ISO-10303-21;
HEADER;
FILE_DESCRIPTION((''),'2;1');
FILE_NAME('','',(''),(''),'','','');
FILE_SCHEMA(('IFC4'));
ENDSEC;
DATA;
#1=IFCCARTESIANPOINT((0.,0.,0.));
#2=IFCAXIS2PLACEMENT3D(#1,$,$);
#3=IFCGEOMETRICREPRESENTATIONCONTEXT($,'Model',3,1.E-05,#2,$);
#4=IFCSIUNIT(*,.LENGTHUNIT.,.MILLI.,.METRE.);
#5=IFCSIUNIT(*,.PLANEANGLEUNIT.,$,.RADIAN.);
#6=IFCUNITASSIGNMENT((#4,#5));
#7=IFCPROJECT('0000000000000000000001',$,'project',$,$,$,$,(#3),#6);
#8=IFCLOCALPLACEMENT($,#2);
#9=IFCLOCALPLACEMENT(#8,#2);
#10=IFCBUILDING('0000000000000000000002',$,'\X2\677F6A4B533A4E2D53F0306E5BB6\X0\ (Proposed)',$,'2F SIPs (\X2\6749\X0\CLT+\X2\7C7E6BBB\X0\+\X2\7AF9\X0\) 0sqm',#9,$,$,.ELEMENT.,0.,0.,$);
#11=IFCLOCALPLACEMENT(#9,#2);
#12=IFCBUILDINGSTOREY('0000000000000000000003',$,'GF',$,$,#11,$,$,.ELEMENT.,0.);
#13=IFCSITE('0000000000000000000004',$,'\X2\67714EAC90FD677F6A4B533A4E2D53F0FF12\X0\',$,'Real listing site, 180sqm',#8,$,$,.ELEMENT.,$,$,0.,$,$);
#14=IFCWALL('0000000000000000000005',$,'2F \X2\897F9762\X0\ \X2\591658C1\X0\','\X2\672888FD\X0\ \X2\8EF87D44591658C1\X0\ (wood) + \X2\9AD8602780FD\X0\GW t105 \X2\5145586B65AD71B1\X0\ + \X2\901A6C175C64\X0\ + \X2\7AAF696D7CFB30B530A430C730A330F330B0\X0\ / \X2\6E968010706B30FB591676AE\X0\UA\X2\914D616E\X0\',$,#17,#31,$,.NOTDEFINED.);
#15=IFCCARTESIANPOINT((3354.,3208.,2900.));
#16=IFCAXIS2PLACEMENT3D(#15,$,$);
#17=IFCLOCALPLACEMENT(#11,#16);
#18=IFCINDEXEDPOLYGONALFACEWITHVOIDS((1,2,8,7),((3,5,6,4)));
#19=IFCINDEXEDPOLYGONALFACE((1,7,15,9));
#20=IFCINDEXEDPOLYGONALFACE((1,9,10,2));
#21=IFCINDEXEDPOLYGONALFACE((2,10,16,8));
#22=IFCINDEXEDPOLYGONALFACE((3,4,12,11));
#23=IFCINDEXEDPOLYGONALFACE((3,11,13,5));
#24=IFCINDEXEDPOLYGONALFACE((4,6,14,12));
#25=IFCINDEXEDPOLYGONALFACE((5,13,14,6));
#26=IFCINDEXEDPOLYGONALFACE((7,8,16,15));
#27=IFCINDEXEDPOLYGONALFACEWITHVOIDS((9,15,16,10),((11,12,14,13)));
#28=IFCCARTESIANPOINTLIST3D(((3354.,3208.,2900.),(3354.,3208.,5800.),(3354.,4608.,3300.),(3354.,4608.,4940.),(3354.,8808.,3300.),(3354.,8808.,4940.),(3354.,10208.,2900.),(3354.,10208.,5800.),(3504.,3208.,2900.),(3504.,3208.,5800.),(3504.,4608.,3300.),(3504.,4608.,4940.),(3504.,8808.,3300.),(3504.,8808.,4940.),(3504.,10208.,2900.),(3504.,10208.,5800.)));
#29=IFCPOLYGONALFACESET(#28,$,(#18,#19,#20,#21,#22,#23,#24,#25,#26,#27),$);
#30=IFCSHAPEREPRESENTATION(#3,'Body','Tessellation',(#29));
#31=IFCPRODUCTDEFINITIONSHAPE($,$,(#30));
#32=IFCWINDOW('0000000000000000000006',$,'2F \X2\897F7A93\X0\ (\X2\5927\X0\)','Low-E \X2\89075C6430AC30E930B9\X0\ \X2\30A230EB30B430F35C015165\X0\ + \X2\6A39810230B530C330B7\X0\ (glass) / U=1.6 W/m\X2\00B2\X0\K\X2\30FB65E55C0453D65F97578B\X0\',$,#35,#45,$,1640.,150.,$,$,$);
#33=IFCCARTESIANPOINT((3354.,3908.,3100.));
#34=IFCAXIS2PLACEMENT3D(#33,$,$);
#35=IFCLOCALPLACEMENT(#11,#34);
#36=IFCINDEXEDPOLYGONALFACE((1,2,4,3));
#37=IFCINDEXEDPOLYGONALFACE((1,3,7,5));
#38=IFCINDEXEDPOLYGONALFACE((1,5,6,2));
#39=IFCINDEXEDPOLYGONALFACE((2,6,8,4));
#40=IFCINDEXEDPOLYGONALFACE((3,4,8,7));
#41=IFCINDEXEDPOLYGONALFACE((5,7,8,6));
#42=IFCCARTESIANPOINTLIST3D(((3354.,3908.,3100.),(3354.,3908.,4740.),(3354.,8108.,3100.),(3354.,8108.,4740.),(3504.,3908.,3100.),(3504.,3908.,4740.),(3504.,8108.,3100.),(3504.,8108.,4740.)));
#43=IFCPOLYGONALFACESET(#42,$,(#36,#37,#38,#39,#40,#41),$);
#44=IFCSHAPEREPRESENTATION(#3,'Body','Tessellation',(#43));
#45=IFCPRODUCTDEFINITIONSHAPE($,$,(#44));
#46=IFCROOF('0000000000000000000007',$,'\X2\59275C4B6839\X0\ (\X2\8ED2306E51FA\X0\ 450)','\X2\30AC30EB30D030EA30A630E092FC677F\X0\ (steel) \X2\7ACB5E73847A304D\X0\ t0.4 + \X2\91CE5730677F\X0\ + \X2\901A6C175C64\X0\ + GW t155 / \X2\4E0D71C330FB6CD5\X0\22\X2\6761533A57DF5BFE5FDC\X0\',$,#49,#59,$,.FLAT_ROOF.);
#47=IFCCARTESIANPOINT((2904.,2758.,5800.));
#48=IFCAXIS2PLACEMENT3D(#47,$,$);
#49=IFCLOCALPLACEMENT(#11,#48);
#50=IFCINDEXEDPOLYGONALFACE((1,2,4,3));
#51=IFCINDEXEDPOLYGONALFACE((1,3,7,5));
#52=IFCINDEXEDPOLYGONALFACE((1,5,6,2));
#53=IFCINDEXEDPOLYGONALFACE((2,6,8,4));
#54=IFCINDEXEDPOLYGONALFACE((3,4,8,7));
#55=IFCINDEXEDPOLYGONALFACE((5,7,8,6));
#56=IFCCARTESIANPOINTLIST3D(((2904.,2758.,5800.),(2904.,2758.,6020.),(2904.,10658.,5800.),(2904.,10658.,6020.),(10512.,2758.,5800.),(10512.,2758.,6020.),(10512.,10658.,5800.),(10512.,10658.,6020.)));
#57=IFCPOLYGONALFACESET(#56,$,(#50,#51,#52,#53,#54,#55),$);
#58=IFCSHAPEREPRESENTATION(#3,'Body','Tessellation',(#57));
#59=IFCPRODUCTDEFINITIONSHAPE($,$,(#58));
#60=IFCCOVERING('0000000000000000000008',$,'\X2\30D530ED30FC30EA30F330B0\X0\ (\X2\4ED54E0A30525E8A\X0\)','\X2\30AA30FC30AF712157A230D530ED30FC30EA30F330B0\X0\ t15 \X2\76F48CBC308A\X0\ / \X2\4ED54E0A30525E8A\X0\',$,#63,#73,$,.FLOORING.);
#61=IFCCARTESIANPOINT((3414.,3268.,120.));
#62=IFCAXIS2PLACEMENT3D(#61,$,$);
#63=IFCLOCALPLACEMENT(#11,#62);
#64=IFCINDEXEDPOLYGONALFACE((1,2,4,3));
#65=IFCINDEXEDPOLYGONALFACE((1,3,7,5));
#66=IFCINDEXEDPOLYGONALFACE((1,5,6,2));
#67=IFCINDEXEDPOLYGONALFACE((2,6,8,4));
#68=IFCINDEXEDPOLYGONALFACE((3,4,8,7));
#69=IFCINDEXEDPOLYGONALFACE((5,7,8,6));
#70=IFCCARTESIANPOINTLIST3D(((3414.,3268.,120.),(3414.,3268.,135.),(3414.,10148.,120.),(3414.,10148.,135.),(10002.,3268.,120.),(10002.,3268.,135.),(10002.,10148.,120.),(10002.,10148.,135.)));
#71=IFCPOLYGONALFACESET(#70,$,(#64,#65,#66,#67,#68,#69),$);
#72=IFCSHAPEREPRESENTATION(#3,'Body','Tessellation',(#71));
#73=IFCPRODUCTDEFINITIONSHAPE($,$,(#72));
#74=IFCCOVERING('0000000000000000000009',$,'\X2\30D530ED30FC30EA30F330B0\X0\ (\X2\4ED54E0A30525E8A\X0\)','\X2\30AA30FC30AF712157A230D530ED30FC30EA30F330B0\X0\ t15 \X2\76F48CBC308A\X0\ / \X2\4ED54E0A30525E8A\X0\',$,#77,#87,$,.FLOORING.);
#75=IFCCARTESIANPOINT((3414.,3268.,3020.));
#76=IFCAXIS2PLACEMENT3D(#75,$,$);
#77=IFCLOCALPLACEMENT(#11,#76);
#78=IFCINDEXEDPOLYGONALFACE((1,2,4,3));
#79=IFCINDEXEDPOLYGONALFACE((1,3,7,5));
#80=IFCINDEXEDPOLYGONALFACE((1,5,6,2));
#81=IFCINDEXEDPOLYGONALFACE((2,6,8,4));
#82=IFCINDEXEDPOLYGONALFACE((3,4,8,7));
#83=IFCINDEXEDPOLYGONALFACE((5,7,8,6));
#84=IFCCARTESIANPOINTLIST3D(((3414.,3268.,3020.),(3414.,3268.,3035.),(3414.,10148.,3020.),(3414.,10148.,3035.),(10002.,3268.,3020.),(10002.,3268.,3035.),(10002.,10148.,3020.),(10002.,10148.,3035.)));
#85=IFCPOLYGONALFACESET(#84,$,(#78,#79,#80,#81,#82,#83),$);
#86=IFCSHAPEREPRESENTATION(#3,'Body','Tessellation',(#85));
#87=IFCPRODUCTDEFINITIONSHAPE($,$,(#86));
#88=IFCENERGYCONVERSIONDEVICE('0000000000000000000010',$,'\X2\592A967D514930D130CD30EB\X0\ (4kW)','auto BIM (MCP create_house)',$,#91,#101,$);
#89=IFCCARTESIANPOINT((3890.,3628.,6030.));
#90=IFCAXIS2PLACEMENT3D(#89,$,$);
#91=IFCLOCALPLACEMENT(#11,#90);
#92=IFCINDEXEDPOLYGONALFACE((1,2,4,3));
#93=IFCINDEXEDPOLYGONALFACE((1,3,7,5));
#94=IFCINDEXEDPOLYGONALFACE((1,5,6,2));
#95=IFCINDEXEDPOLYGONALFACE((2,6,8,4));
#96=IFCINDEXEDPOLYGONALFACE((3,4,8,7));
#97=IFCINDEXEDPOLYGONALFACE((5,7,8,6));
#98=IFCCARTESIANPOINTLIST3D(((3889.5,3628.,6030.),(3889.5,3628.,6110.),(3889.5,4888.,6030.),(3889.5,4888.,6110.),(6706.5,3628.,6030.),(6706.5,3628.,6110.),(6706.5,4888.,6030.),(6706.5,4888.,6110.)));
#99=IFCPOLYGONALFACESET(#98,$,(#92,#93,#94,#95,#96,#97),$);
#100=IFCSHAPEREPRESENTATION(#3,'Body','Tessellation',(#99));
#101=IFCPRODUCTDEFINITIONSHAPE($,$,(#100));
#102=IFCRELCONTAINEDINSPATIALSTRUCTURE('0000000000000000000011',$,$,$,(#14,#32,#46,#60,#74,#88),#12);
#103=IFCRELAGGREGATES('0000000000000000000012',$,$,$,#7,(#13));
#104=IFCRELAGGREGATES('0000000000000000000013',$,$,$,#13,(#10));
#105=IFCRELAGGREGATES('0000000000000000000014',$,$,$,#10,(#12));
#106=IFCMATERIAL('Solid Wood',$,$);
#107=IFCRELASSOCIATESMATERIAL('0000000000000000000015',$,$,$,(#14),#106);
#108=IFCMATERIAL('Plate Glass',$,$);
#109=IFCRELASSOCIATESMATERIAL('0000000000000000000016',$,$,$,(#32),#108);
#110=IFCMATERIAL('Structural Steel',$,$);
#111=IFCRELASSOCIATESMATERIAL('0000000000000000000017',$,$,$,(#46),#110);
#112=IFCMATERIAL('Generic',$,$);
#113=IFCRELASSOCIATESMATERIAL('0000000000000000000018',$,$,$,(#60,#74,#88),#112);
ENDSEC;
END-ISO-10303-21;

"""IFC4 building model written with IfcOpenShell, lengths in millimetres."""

from ifc_helpers import new_model, si_unit, frame, frame_2d, origin, place, context, project, spatial, rectangle, extrude, material, element, fill, save


model = new_model("IFC4")

# Units and contexts
model_context = context("Model", 3, precision=1e-05, world=origin())
ifc_project = project(units=[si_unit("LENGTHUNIT", "METRE", prefix="MILLI"), si_unit("PLANEANGLEUNIT", "RADIAN")], contexts=[model_context])

# Site, building, storey
site_placement = place(None, origin())
site = spatial("IfcSite", under=ifc_project, at=site_placement, Name="東京都板橋区中台２", ObjectType="Real listing site, 180sqm", CompositionType="ELEMENT", RefElevation=0.0)
building_placement = place(site_placement, origin())
building = spatial("IfcBuilding", under=site, at=building_placement, Name="板橋区中台の家 (Proposed)", ObjectType="2F SIPs (杉CLT+籾殻+竹) 0sqm", CompositionType="ELEMENT", ElevationOfRefHeight=0.0, ElevationOfTerrain=0.0)
storey_placement = place(building_placement, origin())
storey = spatial("IfcBuildingStorey", under=building, at=storey_placement, Name="GF", CompositionType="ELEMENT", Elevation=0.0)

# Shared definitions
ifc_material_1 = material(Name="Solid Wood")

# Shared definitions
ifc_material_2 = material(Name="Plate Glass")

# Wall, opening, window
wall_1_placement = place(storey_placement, frame((3354.0, 3208.0, 2900.0)))
wall_1 = element("IfcWall", 1, at=wall_1_placement, inside=storey, material=ifc_material_1, Name="2F 西面 外壁", Description="木製 軸組外壁 (wood) + 高性能GW t105 充填断熱 + 通気層 + 窯業系サイディング / 準耐火・外皮UA配慮", PredefinedType="NOTDEFINED", context=model_context, shape_type="SweptSolid", body=[
    extrude(rectangle(XDim=150.0, YDim=7000.0, at=frame_2d((75.0, 3500.0))), frame((3354.0, 3208.0, 2900.0)), (0.0, 0.0, 1.0), 2900.0),
])
opening_1_placement = place(storey_placement, frame((3354.0, 3908.0, 3100.0)))
opening_1 = element("IfcOpeningElement", 2, at=opening_1_placement, cuts=wall_1, PredefinedType="NOTDEFINED", context=model_context, shape_type="SweptSolid", body=[
    extrude(rectangle(XDim=150.0, YDim=4200.0, at=frame_2d((75.0, 2100.0))), frame((3354.0, 3908.0, 3100.0)), (0.0, 0.0, 1.0), 1640.0),
])
window_1_placement = place(storey_placement, frame((3354.0, 3908.0, 3100.0)))
window_1 = element("IfcWindow", 3, at=window_1_placement, inside=storey, material=ifc_material_2, Name="2F 西窓 (大)", Description="Low-E 複層ガラス アルゴン封入 + 樹脂サッシ (glass) / U=1.6 W/m²K・日射取得型", OverallHeight=1640.0, OverallWidth=150.0, context=model_context, shape_type="SweptSolid", body=[
    extrude(rectangle(XDim=150.0, YDim=4200.0, at=frame_2d((75.0, 2100.0))), frame((3354.0, 3908.0, 3100.0)), (0.0, 0.0, 1.0), 1640.0),
])
fill(opening_1, window_1)

# Roof
ifc_material_3 = material(Name="Structural Steel")
roof_placement = place(storey_placement, frame((2904.0, 2758.0, 5800.0)))
element("IfcRoof", 4, at=roof_placement, inside=storey, material=ifc_material_3, Name="大屋根 (軒の出 450)", Description="ガルバリウム鋼板 (steel) 立平葺き t0.4 + 野地板 + 通気層 + GW t155 / 不燃・法22条区域対応", PredefinedType="FLAT_ROOF", context=model_context, shape_type="SweptSolid", body=[
    extrude(rectangle(XDim=7608.0, YDim=7900.0, at=frame_2d((3804.0, 3950.0))), frame((2904.0, 2758.0, 5800.0)), (0.0, 0.0, 1.0), 220.0),
])

# Coverings
ifc_material_4 = material(Name="Generic")
covering_1_placement = place(storey_placement, frame((3414.0, 3268.0, 120.0)))
element("IfcCovering", 5, at=covering_1_placement, inside=storey, material=ifc_material_4, Name="フローリング (仕上げ床)", Description="オーク無垢フローリング t15 直貼り / 仕上げ床", PredefinedType="FLOORING", context=model_context, shape_type="SweptSolid", body=[
    extrude(rectangle(XDim=6588.0, YDim=6880.0, at=frame_2d((3294.0, 3440.0))), frame((3414.0, 3268.0, 120.0)), (0.0, 0.0, 1.0), 15.0),
])
covering_2_placement = place(storey_placement, frame((3414.0, 3268.0, 3020.0)))
element("IfcCovering", 6, at=covering_2_placement, inside=storey, material=ifc_material_4, Name="フローリング (仕上げ床)", Description="オーク無垢フローリング t15 直貼り / 仕上げ床", PredefinedType="FLOORING", context=model_context, shape_type="SweptSolid", body=[
    extrude(rectangle(XDim=6588.0, YDim=6880.0, at=frame_2d((3294.0, 3440.0))), frame((3414.0, 3268.0, 3020.0)), (0.0, 0.0, 1.0), 15.0),
])

# Energy conversion device
energy_conversion_device_placement = place(storey_placement, frame((3890.0, 3628.0, 6030.0)))
element("IfcEnergyConversionDevice", 7, at=energy_conversion_device_placement, inside=storey, material=ifc_material_4, Name="太陽光パネル (4kW)", Description="auto BIM (MCP create_house)", context=model_context, shape_type="SweptSolid", body=[
    extrude(rectangle(XDim=2817.0, YDim=1260.0, at=frame_2d((1408.0, 630.0))), frame((3890.0, 3628.0, 6030.0)), (0.0, 0.0, 1.0), 80.0),
])

save(model, "model.ifc")
